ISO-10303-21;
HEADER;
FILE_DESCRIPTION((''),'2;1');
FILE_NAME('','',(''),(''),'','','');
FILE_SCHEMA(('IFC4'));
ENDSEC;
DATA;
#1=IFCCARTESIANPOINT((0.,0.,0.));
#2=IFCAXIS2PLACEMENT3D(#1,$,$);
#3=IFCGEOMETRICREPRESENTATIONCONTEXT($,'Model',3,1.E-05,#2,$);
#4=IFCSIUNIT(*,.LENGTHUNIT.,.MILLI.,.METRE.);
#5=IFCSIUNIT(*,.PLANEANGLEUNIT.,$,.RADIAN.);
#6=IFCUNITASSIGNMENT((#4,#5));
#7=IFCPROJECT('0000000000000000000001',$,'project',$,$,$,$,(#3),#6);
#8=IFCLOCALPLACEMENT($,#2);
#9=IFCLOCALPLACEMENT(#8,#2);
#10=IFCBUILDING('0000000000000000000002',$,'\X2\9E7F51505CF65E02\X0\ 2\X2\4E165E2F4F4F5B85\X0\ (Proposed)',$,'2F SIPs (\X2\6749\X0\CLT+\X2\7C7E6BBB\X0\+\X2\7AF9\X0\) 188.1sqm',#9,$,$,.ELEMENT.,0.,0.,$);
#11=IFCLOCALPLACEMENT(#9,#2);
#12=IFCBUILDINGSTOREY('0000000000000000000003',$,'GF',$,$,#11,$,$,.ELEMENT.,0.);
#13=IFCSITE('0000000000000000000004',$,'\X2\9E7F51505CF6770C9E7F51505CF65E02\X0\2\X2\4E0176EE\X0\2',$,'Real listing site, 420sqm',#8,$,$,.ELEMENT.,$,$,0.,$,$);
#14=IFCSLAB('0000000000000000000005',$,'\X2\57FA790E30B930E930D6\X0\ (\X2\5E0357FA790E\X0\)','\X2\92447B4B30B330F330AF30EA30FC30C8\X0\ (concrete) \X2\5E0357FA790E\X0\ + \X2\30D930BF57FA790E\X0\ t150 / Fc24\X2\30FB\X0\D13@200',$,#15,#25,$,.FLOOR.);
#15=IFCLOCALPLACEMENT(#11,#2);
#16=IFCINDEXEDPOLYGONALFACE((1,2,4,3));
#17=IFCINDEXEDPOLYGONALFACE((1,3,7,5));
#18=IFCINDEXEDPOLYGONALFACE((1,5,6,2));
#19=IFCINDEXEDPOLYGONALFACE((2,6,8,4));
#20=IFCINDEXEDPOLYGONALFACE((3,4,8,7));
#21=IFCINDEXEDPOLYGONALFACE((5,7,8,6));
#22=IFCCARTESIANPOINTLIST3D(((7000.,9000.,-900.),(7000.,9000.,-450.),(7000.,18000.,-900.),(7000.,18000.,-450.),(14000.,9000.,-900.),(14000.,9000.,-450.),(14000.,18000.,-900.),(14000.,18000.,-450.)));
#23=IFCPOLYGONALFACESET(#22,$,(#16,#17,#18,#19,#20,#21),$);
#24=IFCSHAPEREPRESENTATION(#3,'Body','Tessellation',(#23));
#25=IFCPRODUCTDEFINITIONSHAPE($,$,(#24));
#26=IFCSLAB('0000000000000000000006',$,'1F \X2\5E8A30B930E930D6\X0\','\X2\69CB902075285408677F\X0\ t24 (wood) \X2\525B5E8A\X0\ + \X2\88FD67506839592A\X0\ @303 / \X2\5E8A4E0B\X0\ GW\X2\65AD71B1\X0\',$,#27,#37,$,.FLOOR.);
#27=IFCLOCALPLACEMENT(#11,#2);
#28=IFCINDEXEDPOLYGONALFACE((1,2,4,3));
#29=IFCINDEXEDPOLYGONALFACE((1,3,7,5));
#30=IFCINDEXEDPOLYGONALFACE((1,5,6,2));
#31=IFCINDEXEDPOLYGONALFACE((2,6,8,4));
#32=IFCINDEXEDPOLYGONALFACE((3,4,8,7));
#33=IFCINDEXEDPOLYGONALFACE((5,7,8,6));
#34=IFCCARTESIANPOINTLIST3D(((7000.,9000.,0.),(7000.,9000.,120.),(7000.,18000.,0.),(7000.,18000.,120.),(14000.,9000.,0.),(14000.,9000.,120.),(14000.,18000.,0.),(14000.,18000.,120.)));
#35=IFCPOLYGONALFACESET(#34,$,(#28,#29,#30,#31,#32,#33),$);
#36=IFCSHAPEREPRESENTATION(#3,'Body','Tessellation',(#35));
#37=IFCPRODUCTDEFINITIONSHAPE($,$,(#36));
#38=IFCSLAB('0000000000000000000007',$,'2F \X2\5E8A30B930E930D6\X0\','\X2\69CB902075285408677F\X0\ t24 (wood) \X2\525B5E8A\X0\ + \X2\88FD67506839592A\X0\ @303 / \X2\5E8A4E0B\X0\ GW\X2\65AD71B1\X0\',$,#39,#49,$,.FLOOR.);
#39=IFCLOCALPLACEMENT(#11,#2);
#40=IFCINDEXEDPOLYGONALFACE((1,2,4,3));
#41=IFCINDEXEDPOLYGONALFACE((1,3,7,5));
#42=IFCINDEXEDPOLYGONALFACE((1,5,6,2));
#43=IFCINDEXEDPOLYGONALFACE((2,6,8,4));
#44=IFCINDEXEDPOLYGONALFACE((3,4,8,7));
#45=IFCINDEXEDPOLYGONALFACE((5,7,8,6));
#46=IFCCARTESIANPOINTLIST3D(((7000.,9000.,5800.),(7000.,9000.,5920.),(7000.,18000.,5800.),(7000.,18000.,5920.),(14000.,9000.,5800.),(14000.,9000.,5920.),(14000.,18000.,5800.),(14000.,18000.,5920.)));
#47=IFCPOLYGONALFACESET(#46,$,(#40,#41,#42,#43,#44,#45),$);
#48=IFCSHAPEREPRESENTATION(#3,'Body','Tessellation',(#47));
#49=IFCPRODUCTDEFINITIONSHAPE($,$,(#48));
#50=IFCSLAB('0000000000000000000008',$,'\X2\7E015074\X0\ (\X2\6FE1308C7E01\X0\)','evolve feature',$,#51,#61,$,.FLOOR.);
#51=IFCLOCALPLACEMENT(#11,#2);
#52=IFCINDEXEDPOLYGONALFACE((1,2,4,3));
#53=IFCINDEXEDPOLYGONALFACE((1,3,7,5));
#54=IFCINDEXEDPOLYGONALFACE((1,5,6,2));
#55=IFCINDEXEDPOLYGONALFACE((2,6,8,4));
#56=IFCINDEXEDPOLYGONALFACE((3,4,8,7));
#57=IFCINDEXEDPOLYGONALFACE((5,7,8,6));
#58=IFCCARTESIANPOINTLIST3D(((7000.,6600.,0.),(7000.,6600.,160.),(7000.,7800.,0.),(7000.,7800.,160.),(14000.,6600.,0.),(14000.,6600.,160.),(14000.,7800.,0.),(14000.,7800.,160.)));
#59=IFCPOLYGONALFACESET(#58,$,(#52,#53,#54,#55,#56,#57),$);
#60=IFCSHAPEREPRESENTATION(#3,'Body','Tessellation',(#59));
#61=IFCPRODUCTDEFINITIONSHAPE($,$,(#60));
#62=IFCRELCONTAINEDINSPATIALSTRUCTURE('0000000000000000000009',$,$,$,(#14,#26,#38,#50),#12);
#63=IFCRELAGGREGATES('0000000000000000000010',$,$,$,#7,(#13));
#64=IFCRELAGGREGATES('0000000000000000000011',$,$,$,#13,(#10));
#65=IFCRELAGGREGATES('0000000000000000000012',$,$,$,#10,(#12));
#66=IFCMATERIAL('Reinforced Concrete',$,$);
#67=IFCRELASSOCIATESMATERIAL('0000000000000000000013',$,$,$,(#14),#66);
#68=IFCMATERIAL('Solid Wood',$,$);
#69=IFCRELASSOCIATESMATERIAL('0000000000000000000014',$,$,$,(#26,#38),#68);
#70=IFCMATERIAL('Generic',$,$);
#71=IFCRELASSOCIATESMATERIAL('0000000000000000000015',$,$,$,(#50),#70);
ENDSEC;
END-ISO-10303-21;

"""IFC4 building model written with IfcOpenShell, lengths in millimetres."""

from ifc_helpers import new_model, si_unit, frame, frame_2d, origin, place, context, project, spatial, rectangle, extrude, material, element, save


model = new_model("IFC4")

# Units and contexts
model_context = context("Model", 3, precision=1e-05, world=origin())
ifc_project = project(units=[si_unit("LENGTHUNIT", "METRE", prefix="MILLI"), si_unit("PLANEANGLEUNIT", "RADIAN")], contexts=[model_context])

# Site, building, storey
site_placement = place(None, origin())
site = spatial("IfcSite", under=ifc_project, at=site_placement, Name="鹿児島県鹿児島市2丁目2", ObjectType="Real listing site, 420sqm", CompositionType="ELEMENT", RefElevation=0.0)
building_placement = place(site_placement, origin())
building = spatial("IfcBuilding", under=site, at=building_placement, Name="鹿児島市 2世帯住宅 (Proposed)", ObjectType="2F SIPs (杉CLT+籾殻+竹) 188.1sqm", CompositionType="ELEMENT", ElevationOfRefHeight=0.0, ElevationOfTerrain=0.0)
storey_placement = place(building_placement, origin())
storey = spatial("IfcBuildingStorey", under=building, at=storey_placement, Name="GF", CompositionType="ELEMENT", Elevation=0.0)

# Slabs
ifc_material_1 = material(Name="Reinforced Concrete")
slab_1_placement = place(storey_placement, frame((3500.0, 4500.0, -450.0)))
element("IfcSlab", 1, at=slab_1_placement, inside=storey, material=ifc_material_1, Name="基礎スラブ (布基礎)", Description="鉄筋コンクリート (concrete) 布基礎 + ベタ基礎 t150 / Fc24・D13@200", PredefinedType="FLOOR", context=model_context, shape_type="SweptSolid", body=[
    extrude(rectangle(XDim=7000.0, YDim=9000.0, at=frame_2d((3500.0, 4500.0))), frame((3500.0, 4500.0, -450.0)), (0.0, 0.0, 1.0), 450.0),
])
ifc_material_2 = material(Name="Solid Wood")
slab_2_placement = place(storey_placement, frame((3500.0, 4500.0, 0.0)))
element("IfcSlab", 2, at=slab_2_placement, inside=storey, material=ifc_material_2, Name="1F 床スラブ", Description="構造用合板 t24 (wood) 剛床 + 製材根太 @303 / 床下 GW断熱", PredefinedType="FLOOR", context=model_context, shape_type="SweptSolid", body=[
    extrude(rectangle(XDim=7000.0, YDim=9000.0, at=frame_2d((3500.0, 4500.0))), frame((3500.0, 4500.0, 0.0)), (0.0, 0.0, 1.0), 120.0),
])
slab_3_placement = place(storey_placement, frame((3500.0, 4500.0, 2900.0)))
element("IfcSlab", 3, at=slab_3_placement, inside=storey, material=ifc_material_2, Name="2F 床スラブ", Description="構造用合板 t24 (wood) 剛床 + 製材根太 @303 / 床下 GW断熱", PredefinedType="FLOOR", context=model_context, shape_type="SweptSolid", body=[
    extrude(rectangle(XDim=7000.0, YDim=9000.0, at=frame_2d((3500.0, 4500.0))), frame((3500.0, 4500.0, 2900.0)), (0.0, 0.0, 1.0), 120.0),
])
ifc_material_3 = material(Name="Generic")
slab_4_placement = place(storey_placement, frame((3500.0, 3300.0, 0.0)))
element("IfcSlab", 4, at=slab_4_placement, inside=storey, material=ifc_material_3, Name="縁側 (濡れ縁)", Description="evolve feature", PredefinedType="FLOOR", context=model_context, shape_type="SweptSolid", body=[
    extrude(rectangle(XDim=7000.0, YDim=1200.0, at=frame_2d((3500.0, 600.0))), frame((3500.0, 3300.0, 0.0)), (0.0, 0.0, 1.0), 160.0),
])

save(model, "model.ifc")
